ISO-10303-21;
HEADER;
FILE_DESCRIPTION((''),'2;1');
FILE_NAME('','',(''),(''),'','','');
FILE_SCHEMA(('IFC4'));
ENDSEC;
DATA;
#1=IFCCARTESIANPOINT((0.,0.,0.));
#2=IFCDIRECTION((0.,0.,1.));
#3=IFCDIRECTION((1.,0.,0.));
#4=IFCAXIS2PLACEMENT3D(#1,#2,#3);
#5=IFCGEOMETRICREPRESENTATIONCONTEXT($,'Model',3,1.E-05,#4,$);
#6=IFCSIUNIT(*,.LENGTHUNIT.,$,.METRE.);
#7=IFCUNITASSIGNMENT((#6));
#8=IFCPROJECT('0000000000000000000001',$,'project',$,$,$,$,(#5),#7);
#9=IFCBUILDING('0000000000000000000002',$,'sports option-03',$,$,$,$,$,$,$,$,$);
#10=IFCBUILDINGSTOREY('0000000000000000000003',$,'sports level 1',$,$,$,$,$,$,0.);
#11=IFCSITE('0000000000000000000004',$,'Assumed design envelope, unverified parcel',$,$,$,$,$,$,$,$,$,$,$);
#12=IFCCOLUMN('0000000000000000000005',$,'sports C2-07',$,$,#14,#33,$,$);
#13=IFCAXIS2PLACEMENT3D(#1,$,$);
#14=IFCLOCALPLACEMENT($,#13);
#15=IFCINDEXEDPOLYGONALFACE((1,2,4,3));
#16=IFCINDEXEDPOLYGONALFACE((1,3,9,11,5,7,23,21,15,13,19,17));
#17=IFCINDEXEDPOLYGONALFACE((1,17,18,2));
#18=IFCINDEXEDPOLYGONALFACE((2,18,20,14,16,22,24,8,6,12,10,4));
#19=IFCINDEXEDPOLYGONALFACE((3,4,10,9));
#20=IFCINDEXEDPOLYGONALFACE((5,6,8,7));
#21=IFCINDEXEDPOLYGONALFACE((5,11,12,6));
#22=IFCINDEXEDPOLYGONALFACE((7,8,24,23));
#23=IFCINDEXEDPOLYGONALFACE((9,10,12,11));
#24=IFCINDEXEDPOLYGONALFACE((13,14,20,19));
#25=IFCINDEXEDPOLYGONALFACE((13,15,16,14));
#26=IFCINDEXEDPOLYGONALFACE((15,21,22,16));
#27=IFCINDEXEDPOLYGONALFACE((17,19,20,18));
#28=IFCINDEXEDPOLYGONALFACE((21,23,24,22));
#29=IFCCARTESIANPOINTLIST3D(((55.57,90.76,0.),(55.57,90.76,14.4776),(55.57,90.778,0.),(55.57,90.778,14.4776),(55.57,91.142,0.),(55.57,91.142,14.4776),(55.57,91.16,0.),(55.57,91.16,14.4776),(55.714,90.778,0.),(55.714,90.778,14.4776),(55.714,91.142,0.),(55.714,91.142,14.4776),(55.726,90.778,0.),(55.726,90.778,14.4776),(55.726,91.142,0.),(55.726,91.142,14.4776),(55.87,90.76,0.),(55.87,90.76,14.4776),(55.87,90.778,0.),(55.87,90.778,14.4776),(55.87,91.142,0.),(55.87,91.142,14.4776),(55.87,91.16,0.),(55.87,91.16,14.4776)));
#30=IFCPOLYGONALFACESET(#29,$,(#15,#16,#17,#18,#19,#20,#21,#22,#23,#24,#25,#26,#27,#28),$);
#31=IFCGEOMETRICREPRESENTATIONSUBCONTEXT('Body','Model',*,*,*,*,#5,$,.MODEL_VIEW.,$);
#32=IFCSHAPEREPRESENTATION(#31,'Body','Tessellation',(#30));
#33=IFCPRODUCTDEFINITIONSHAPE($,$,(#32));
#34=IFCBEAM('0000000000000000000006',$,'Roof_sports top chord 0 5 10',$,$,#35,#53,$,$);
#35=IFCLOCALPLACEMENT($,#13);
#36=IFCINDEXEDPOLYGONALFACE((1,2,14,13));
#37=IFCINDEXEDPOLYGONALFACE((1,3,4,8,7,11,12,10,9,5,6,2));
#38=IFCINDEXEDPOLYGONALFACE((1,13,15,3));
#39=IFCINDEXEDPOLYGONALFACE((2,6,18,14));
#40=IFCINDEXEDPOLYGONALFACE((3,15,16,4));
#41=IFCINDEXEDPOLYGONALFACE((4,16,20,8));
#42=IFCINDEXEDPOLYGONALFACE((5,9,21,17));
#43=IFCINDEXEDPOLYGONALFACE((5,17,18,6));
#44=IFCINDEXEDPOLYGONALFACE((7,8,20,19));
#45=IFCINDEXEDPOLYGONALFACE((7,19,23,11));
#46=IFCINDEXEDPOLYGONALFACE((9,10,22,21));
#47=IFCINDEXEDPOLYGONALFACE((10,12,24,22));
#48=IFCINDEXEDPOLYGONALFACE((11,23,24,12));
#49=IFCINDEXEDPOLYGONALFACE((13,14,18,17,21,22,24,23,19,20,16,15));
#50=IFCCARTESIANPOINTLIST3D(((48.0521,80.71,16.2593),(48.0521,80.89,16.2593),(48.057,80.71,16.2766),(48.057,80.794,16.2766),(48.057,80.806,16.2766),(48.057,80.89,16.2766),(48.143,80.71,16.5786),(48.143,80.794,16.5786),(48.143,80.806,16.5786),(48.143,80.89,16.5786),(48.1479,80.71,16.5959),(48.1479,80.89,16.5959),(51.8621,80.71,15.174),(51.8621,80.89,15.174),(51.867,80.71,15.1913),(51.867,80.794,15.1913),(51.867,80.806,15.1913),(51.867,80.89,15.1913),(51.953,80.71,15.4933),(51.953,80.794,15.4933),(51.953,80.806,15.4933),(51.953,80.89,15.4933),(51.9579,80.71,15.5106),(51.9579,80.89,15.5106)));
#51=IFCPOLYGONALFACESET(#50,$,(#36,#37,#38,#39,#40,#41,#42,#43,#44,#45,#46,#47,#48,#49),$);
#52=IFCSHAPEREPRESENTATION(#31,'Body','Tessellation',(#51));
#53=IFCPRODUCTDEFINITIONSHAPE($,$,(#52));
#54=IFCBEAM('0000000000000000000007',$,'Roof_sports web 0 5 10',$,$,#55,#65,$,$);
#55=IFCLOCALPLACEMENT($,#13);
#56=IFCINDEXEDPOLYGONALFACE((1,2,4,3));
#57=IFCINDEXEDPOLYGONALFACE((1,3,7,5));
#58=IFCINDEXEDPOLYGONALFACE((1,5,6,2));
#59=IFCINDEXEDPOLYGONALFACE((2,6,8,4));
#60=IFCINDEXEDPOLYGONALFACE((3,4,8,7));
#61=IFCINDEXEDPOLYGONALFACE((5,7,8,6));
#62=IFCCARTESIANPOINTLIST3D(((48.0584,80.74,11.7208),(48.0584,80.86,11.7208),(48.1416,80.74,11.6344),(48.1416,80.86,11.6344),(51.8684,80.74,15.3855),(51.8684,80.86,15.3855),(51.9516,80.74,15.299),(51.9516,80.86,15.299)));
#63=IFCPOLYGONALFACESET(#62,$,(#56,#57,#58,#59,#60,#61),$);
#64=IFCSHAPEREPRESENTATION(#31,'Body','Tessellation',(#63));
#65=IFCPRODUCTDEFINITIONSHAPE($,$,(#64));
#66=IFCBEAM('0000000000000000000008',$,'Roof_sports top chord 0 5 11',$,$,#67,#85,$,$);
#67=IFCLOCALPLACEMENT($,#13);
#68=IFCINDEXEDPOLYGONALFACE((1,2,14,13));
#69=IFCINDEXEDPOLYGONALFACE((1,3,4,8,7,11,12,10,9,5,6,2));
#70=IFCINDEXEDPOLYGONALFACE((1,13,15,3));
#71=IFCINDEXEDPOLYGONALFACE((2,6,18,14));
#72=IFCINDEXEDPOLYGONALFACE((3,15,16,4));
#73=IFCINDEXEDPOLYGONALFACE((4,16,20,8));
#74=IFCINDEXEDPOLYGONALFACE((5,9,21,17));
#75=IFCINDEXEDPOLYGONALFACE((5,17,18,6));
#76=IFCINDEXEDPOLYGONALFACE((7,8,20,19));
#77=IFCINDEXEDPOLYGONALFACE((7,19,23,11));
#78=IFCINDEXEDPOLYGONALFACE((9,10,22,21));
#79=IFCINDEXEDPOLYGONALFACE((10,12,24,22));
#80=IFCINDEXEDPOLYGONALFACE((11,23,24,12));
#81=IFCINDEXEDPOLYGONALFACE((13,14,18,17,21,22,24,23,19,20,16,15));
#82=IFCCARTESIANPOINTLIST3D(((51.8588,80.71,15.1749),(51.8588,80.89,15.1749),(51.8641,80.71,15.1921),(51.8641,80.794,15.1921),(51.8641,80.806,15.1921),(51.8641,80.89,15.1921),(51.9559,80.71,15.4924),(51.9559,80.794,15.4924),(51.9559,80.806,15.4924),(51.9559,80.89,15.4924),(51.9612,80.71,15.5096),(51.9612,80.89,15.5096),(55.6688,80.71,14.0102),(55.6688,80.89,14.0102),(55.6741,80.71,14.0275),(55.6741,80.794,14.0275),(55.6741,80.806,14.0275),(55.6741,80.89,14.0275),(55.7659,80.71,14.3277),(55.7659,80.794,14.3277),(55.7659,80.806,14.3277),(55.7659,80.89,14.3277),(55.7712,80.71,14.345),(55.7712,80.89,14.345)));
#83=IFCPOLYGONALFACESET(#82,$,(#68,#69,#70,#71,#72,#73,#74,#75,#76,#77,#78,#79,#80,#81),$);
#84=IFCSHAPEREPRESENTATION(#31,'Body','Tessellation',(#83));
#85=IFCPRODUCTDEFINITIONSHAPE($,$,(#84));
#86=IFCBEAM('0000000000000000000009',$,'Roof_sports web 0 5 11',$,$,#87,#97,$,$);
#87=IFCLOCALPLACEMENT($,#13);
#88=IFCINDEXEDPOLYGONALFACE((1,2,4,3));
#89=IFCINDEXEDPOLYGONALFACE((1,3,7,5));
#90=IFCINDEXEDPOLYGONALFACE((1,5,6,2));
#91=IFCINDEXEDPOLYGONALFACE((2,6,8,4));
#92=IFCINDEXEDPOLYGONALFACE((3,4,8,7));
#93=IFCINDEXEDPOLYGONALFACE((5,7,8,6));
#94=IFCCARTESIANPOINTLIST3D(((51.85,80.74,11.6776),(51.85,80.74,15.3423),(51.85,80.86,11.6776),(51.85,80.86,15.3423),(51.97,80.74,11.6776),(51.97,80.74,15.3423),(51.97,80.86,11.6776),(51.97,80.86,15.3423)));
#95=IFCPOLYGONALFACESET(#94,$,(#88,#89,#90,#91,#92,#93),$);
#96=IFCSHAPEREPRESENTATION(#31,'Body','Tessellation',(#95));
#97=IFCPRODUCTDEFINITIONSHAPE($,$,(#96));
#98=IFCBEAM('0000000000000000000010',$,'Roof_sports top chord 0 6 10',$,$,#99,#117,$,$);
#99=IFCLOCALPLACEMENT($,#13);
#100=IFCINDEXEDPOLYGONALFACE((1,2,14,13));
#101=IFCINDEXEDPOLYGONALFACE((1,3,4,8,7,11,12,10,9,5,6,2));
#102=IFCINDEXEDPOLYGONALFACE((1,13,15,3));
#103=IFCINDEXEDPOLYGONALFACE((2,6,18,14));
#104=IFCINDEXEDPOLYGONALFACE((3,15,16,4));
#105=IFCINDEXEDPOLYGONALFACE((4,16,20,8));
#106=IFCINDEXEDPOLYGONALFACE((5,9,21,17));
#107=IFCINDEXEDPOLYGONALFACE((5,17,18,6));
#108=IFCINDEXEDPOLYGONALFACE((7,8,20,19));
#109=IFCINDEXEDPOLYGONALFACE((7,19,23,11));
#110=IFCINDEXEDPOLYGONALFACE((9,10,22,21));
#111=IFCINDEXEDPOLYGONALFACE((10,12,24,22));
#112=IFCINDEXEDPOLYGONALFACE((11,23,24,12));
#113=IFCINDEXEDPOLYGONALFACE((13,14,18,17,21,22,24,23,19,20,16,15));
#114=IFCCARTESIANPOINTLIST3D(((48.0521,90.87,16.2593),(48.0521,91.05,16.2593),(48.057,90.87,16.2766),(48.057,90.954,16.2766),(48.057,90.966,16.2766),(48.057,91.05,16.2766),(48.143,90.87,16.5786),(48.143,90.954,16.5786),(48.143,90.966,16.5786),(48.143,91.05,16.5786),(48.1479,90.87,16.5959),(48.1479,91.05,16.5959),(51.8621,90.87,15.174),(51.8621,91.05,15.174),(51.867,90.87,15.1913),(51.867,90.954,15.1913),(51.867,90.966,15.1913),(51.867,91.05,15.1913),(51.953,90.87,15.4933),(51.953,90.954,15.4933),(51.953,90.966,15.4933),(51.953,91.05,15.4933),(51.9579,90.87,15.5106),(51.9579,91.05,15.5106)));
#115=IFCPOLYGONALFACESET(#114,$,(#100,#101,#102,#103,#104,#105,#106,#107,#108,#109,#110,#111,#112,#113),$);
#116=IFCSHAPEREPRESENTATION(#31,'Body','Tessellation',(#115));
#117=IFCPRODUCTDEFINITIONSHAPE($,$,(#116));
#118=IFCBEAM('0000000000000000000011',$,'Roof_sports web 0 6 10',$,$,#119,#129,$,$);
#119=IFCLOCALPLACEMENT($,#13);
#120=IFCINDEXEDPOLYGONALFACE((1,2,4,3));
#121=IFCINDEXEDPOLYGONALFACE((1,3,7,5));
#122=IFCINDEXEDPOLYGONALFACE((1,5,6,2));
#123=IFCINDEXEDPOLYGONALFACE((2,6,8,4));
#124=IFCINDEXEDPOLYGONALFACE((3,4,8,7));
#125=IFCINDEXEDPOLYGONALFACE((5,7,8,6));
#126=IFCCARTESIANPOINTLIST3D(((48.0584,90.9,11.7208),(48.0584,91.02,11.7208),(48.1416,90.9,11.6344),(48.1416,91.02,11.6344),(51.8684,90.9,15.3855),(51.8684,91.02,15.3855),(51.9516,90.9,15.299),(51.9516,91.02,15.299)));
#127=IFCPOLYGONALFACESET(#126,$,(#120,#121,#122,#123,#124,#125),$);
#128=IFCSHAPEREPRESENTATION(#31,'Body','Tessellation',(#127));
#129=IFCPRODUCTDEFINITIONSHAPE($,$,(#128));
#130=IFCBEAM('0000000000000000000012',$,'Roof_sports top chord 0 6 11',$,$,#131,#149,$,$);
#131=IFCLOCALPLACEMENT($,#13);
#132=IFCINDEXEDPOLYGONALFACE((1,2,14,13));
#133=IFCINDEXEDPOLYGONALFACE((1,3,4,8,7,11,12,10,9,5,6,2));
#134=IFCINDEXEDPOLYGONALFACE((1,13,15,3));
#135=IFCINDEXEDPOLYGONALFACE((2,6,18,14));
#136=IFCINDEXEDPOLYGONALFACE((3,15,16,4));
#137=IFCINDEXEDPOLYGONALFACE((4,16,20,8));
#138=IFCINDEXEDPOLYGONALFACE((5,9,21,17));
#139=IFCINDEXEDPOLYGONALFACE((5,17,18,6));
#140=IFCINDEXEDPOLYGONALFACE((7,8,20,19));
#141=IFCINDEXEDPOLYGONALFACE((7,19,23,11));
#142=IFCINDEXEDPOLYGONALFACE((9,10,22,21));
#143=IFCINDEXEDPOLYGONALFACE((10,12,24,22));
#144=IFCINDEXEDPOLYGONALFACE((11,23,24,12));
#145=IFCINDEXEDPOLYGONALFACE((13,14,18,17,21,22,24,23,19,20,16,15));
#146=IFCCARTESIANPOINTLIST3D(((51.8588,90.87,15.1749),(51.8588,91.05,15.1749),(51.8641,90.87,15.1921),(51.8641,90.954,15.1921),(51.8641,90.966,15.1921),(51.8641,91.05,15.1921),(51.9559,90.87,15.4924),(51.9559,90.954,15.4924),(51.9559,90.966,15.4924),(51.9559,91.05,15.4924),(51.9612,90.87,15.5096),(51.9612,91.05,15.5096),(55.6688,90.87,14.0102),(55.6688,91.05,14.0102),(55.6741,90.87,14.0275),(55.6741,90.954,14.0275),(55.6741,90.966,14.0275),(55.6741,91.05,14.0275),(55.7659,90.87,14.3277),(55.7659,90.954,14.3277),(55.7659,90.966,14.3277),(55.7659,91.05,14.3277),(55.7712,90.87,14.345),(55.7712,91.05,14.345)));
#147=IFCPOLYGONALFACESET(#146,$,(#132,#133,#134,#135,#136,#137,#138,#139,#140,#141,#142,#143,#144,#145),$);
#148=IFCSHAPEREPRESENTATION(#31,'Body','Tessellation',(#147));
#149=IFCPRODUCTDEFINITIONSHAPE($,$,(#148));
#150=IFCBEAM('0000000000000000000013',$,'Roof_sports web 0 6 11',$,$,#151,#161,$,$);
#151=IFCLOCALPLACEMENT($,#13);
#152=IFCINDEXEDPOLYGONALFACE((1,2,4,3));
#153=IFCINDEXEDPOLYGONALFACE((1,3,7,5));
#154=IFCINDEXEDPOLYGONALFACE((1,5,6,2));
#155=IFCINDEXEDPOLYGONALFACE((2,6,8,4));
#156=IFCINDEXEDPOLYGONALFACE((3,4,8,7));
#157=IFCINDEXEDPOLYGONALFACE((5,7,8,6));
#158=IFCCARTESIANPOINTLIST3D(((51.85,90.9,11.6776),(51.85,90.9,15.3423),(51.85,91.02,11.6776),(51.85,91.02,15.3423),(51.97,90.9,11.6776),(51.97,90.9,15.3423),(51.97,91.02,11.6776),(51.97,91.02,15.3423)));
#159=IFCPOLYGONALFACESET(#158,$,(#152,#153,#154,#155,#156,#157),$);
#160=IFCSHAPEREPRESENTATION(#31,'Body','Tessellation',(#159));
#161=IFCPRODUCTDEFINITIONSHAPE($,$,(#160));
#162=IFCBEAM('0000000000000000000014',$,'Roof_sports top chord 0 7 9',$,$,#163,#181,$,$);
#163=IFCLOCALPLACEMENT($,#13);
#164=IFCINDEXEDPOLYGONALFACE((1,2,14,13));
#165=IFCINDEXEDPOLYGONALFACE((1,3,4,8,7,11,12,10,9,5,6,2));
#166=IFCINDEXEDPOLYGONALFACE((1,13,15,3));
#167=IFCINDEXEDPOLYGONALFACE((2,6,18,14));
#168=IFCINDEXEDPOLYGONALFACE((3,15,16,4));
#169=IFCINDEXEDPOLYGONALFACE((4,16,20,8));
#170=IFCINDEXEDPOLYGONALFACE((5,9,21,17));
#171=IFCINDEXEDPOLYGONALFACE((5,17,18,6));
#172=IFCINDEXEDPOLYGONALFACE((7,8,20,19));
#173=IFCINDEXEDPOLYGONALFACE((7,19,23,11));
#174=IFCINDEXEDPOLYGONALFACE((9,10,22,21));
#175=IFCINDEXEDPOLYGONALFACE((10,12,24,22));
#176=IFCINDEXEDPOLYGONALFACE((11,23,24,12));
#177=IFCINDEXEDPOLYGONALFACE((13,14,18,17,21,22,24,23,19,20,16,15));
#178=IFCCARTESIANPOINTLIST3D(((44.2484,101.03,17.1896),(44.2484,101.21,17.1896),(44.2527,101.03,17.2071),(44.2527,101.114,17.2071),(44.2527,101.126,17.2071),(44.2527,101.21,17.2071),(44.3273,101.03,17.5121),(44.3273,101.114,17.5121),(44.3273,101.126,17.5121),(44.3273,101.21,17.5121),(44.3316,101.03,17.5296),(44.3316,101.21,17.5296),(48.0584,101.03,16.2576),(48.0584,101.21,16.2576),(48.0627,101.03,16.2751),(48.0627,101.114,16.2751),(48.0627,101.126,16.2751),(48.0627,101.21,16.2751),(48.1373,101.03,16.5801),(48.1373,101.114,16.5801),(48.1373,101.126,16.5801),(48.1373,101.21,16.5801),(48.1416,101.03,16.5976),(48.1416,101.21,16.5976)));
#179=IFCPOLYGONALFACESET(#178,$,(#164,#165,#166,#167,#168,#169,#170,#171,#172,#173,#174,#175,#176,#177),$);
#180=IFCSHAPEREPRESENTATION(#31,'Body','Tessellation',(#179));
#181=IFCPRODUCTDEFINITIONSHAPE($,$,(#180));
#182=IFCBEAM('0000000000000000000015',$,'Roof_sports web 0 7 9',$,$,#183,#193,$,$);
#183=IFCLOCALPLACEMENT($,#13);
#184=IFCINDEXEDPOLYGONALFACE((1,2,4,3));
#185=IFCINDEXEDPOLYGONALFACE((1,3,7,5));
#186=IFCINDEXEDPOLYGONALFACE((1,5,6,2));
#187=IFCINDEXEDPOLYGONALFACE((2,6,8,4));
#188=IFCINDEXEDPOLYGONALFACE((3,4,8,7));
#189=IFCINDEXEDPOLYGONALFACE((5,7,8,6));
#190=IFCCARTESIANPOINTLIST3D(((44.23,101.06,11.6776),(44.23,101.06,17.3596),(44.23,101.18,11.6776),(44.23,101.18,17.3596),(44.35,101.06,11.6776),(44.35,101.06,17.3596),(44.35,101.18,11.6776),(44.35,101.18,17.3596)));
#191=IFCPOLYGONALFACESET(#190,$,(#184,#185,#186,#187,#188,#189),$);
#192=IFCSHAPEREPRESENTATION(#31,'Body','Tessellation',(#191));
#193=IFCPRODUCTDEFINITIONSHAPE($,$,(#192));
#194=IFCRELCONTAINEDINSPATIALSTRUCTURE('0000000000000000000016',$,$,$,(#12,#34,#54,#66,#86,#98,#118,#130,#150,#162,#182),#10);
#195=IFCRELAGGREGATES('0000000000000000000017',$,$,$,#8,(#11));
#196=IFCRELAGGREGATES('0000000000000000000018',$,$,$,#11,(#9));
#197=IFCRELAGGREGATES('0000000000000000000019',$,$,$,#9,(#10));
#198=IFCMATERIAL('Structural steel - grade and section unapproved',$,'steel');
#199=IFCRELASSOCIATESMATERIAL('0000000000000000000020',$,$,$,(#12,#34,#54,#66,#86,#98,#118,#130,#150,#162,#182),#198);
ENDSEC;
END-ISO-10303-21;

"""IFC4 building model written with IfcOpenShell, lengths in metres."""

from ifc_helpers import new_model, si_unit, frame, origin_with_axes, place, context, subcontext, project, spatial, rectangle, i_section, extrude, material, element, save


model = new_model("IFC4")

# Units and contexts
model_context = context("Model", 3, precision=1e-05, world=origin_with_axes())
body_context = subcontext(model_context, "Body", "Model", "MODEL_VIEW")
ifc_project = project(units=[si_unit("LENGTHUNIT", "METRE")], contexts=[model_context])

# Site, building, storey
site = spatial("IfcSite", under=ifc_project, Name="Assumed design envelope, unverified parcel")
building = spatial("IfcBuilding", under=site, Name="sports option-03")
storey = spatial("IfcBuildingStorey", under=building, Name="sports level 1", Elevation=0.0)

# Column
ifc_material = material(Name="Structural steel - grade and section unapproved", Category="steel")
column_placement = place(None, frame((55.72, 90.96, 0.0), z_axis=(0.0, 0.0, 1.0), x_axis=(-1.0, 0.0, 0.0)))
element("IfcColumn", 1, at=column_placement, inside=storey, material=ifc_material, Name="sports C2-07", context=body_context, shape_type="SweptSolid", body=[
    extrude(i_section(OverallWidth=0.3, OverallDepth=0.4, WebThickness=0.012, FlangeThickness=0.018, FilletRadius=0.0), origin_with_axes(), (0.0, 0.0, 1.0), 14.4776),
])

# Beams
beam_1_placement = place(None, frame((48.1, 80.8, 16.4276), z_axis=(0.961741, 0.0, -0.273961), x_axis=(0.0, 1.0, 0.0)))
element("IfcBeam", 2, at=beam_1_placement, inside=storey, material=ifc_material, Name="Roof_sports top chord 0 5 10", context=body_context, shape_type="SweptSolid", body=[
    extrude(i_section(OverallWidth=0.18, OverallDepth=0.35, WebThickness=0.012, FlangeThickness=0.018, FilletRadius=0.0), origin_with_axes(), (0.0, 0.0, 1.0), 3.9616),
])
beam_2_placement = place(None, frame((48.1, 80.8, 11.6776), z_axis=(0.720717, 0.0, 0.693229), x_axis=(0.0, 1.0, 0.0)))
element("IfcBeam", 3, at=beam_2_placement, inside=storey, material=ifc_material, Name="Roof_sports web 0 5 10", context=body_context, shape_type="SweptSolid", body=[
    extrude(rectangle(XDim=0.12, YDim=0.12), origin_with_axes(), (0.0, 0.0, 1.0), 5.2864),
])
beam_3_placement = place(None, frame((51.91, 80.8, 15.3423), z_axis=(0.956315, 0.0, -0.292337), x_axis=(0.0, 1.0, 0.0)))
element("IfcBeam", 4, at=beam_3_placement, inside=storey, material=ifc_material, Name="Roof_sports top chord 0 5 11", context=body_context, shape_type="SweptSolid", body=[
    extrude(i_section(OverallWidth=0.18, OverallDepth=0.35, WebThickness=0.012, FlangeThickness=0.018, FilletRadius=0.0), origin_with_axes(), (0.0, 0.0, 1.0), 3.984),
])
beam_4_placement = place(None, frame((51.91, 80.8, 11.6776), z_axis=(0.0, 0.0, 1.0), x_axis=(-1.0, 0.0, 0.0)))
element("IfcBeam", 5, at=beam_4_placement, inside=storey, material=ifc_material, Name="Roof_sports web 0 5 11", context=body_context, shape_type="SweptSolid", body=[
    extrude(rectangle(XDim=0.12, YDim=0.12), origin_with_axes(), (0.0, 0.0, 1.0), 3.6647),
])
beam_5_placement = place(None, frame((48.1, 90.96, 16.4276), z_axis=(0.961741, 0.0, -0.273961), x_axis=(0.0, 1.0, 0.0)))
element("IfcBeam", 6, at=beam_5_placement, inside=storey, material=ifc_material, Name="Roof_sports top chord 0 6 10", context=body_context, shape_type="SweptSolid", body=[
    extrude(i_section(OverallWidth=0.18, OverallDepth=0.35, WebThickness=0.012, FlangeThickness=0.018, FilletRadius=0.0), origin_with_axes(), (0.0, 0.0, 1.0), 3.9616),
])
beam_6_placement = place(None, frame((48.1, 90.96, 11.6776), z_axis=(0.720717, 0.0, 0.693229), x_axis=(0.0, 1.0, 0.0)))
element("IfcBeam", 7, at=beam_6_placement, inside=storey, material=ifc_material, Name="Roof_sports web 0 6 10", context=body_context, shape_type="SweptSolid", body=[
    extrude(rectangle(XDim=0.12, YDim=0.12), origin_with_axes(), (0.0, 0.0, 1.0), 5.2864),
])
beam_7_placement = place(None, frame((51.91, 90.96, 15.3423), z_axis=(0.956315, 0.0, -0.292337), x_axis=(0.0, 1.0, 0.0)))
element("IfcBeam", 8, at=beam_7_placement, inside=storey, material=ifc_material, Name="Roof_sports top chord 0 6 11", context=body_context, shape_type="SweptSolid", body=[
    extrude(i_section(OverallWidth=0.18, OverallDepth=0.35, WebThickness=0.012, FlangeThickness=0.018, FilletRadius=0.0), origin_with_axes(), (0.0, 0.0, 1.0), 3.984),
])
beam_8_placement = place(None, frame((51.91, 90.96, 11.6776), z_axis=(0.0, 0.0, 1.0), x_axis=(-1.0, 0.0, 0.0)))
element("IfcBeam", 9, at=beam_8_placement, inside=storey, material=ifc_material, Name="Roof_sports web 0 6 11", context=body_context, shape_type="SweptSolid", body=[
    extrude(rectangle(XDim=0.12, YDim=0.12), origin_with_axes(), (0.0, 0.0, 1.0), 3.6647),
])
beam_9_placement = place(None, frame((44.29, 101.12, 17.3596), z_axis=(0.971361, 0.0, -0.237609), x_axis=(0.0, 1.0, 0.0)))
element("IfcBeam", 10, at=beam_9_placement, inside=storey, material=ifc_material, Name="Roof_sports top chord 0 7 9", context=body_context, shape_type="SweptSolid", body=[
    extrude(i_section(OverallWidth=0.18, OverallDepth=0.35, WebThickness=0.012, FlangeThickness=0.018, FilletRadius=0.0), origin_with_axes(), (0.0, 0.0, 1.0), 3.9223),
])
beam_10_placement = place(None, frame((44.29, 101.12, 11.6776), z_axis=(0.0, 0.0, 1.0), x_axis=(-1.0, 0.0, 0.0)))
element("IfcBeam", 11, at=beam_10_placement, inside=storey, material=ifc_material, Name="Roof_sports web 0 7 9", context=body_context, shape_type="SweptSolid", body=[
    extrude(rectangle(XDim=0.12, YDim=0.12), origin_with_axes(), (0.0, 0.0, 1.0), 5.682),
])

save(model, "model.ifc")
